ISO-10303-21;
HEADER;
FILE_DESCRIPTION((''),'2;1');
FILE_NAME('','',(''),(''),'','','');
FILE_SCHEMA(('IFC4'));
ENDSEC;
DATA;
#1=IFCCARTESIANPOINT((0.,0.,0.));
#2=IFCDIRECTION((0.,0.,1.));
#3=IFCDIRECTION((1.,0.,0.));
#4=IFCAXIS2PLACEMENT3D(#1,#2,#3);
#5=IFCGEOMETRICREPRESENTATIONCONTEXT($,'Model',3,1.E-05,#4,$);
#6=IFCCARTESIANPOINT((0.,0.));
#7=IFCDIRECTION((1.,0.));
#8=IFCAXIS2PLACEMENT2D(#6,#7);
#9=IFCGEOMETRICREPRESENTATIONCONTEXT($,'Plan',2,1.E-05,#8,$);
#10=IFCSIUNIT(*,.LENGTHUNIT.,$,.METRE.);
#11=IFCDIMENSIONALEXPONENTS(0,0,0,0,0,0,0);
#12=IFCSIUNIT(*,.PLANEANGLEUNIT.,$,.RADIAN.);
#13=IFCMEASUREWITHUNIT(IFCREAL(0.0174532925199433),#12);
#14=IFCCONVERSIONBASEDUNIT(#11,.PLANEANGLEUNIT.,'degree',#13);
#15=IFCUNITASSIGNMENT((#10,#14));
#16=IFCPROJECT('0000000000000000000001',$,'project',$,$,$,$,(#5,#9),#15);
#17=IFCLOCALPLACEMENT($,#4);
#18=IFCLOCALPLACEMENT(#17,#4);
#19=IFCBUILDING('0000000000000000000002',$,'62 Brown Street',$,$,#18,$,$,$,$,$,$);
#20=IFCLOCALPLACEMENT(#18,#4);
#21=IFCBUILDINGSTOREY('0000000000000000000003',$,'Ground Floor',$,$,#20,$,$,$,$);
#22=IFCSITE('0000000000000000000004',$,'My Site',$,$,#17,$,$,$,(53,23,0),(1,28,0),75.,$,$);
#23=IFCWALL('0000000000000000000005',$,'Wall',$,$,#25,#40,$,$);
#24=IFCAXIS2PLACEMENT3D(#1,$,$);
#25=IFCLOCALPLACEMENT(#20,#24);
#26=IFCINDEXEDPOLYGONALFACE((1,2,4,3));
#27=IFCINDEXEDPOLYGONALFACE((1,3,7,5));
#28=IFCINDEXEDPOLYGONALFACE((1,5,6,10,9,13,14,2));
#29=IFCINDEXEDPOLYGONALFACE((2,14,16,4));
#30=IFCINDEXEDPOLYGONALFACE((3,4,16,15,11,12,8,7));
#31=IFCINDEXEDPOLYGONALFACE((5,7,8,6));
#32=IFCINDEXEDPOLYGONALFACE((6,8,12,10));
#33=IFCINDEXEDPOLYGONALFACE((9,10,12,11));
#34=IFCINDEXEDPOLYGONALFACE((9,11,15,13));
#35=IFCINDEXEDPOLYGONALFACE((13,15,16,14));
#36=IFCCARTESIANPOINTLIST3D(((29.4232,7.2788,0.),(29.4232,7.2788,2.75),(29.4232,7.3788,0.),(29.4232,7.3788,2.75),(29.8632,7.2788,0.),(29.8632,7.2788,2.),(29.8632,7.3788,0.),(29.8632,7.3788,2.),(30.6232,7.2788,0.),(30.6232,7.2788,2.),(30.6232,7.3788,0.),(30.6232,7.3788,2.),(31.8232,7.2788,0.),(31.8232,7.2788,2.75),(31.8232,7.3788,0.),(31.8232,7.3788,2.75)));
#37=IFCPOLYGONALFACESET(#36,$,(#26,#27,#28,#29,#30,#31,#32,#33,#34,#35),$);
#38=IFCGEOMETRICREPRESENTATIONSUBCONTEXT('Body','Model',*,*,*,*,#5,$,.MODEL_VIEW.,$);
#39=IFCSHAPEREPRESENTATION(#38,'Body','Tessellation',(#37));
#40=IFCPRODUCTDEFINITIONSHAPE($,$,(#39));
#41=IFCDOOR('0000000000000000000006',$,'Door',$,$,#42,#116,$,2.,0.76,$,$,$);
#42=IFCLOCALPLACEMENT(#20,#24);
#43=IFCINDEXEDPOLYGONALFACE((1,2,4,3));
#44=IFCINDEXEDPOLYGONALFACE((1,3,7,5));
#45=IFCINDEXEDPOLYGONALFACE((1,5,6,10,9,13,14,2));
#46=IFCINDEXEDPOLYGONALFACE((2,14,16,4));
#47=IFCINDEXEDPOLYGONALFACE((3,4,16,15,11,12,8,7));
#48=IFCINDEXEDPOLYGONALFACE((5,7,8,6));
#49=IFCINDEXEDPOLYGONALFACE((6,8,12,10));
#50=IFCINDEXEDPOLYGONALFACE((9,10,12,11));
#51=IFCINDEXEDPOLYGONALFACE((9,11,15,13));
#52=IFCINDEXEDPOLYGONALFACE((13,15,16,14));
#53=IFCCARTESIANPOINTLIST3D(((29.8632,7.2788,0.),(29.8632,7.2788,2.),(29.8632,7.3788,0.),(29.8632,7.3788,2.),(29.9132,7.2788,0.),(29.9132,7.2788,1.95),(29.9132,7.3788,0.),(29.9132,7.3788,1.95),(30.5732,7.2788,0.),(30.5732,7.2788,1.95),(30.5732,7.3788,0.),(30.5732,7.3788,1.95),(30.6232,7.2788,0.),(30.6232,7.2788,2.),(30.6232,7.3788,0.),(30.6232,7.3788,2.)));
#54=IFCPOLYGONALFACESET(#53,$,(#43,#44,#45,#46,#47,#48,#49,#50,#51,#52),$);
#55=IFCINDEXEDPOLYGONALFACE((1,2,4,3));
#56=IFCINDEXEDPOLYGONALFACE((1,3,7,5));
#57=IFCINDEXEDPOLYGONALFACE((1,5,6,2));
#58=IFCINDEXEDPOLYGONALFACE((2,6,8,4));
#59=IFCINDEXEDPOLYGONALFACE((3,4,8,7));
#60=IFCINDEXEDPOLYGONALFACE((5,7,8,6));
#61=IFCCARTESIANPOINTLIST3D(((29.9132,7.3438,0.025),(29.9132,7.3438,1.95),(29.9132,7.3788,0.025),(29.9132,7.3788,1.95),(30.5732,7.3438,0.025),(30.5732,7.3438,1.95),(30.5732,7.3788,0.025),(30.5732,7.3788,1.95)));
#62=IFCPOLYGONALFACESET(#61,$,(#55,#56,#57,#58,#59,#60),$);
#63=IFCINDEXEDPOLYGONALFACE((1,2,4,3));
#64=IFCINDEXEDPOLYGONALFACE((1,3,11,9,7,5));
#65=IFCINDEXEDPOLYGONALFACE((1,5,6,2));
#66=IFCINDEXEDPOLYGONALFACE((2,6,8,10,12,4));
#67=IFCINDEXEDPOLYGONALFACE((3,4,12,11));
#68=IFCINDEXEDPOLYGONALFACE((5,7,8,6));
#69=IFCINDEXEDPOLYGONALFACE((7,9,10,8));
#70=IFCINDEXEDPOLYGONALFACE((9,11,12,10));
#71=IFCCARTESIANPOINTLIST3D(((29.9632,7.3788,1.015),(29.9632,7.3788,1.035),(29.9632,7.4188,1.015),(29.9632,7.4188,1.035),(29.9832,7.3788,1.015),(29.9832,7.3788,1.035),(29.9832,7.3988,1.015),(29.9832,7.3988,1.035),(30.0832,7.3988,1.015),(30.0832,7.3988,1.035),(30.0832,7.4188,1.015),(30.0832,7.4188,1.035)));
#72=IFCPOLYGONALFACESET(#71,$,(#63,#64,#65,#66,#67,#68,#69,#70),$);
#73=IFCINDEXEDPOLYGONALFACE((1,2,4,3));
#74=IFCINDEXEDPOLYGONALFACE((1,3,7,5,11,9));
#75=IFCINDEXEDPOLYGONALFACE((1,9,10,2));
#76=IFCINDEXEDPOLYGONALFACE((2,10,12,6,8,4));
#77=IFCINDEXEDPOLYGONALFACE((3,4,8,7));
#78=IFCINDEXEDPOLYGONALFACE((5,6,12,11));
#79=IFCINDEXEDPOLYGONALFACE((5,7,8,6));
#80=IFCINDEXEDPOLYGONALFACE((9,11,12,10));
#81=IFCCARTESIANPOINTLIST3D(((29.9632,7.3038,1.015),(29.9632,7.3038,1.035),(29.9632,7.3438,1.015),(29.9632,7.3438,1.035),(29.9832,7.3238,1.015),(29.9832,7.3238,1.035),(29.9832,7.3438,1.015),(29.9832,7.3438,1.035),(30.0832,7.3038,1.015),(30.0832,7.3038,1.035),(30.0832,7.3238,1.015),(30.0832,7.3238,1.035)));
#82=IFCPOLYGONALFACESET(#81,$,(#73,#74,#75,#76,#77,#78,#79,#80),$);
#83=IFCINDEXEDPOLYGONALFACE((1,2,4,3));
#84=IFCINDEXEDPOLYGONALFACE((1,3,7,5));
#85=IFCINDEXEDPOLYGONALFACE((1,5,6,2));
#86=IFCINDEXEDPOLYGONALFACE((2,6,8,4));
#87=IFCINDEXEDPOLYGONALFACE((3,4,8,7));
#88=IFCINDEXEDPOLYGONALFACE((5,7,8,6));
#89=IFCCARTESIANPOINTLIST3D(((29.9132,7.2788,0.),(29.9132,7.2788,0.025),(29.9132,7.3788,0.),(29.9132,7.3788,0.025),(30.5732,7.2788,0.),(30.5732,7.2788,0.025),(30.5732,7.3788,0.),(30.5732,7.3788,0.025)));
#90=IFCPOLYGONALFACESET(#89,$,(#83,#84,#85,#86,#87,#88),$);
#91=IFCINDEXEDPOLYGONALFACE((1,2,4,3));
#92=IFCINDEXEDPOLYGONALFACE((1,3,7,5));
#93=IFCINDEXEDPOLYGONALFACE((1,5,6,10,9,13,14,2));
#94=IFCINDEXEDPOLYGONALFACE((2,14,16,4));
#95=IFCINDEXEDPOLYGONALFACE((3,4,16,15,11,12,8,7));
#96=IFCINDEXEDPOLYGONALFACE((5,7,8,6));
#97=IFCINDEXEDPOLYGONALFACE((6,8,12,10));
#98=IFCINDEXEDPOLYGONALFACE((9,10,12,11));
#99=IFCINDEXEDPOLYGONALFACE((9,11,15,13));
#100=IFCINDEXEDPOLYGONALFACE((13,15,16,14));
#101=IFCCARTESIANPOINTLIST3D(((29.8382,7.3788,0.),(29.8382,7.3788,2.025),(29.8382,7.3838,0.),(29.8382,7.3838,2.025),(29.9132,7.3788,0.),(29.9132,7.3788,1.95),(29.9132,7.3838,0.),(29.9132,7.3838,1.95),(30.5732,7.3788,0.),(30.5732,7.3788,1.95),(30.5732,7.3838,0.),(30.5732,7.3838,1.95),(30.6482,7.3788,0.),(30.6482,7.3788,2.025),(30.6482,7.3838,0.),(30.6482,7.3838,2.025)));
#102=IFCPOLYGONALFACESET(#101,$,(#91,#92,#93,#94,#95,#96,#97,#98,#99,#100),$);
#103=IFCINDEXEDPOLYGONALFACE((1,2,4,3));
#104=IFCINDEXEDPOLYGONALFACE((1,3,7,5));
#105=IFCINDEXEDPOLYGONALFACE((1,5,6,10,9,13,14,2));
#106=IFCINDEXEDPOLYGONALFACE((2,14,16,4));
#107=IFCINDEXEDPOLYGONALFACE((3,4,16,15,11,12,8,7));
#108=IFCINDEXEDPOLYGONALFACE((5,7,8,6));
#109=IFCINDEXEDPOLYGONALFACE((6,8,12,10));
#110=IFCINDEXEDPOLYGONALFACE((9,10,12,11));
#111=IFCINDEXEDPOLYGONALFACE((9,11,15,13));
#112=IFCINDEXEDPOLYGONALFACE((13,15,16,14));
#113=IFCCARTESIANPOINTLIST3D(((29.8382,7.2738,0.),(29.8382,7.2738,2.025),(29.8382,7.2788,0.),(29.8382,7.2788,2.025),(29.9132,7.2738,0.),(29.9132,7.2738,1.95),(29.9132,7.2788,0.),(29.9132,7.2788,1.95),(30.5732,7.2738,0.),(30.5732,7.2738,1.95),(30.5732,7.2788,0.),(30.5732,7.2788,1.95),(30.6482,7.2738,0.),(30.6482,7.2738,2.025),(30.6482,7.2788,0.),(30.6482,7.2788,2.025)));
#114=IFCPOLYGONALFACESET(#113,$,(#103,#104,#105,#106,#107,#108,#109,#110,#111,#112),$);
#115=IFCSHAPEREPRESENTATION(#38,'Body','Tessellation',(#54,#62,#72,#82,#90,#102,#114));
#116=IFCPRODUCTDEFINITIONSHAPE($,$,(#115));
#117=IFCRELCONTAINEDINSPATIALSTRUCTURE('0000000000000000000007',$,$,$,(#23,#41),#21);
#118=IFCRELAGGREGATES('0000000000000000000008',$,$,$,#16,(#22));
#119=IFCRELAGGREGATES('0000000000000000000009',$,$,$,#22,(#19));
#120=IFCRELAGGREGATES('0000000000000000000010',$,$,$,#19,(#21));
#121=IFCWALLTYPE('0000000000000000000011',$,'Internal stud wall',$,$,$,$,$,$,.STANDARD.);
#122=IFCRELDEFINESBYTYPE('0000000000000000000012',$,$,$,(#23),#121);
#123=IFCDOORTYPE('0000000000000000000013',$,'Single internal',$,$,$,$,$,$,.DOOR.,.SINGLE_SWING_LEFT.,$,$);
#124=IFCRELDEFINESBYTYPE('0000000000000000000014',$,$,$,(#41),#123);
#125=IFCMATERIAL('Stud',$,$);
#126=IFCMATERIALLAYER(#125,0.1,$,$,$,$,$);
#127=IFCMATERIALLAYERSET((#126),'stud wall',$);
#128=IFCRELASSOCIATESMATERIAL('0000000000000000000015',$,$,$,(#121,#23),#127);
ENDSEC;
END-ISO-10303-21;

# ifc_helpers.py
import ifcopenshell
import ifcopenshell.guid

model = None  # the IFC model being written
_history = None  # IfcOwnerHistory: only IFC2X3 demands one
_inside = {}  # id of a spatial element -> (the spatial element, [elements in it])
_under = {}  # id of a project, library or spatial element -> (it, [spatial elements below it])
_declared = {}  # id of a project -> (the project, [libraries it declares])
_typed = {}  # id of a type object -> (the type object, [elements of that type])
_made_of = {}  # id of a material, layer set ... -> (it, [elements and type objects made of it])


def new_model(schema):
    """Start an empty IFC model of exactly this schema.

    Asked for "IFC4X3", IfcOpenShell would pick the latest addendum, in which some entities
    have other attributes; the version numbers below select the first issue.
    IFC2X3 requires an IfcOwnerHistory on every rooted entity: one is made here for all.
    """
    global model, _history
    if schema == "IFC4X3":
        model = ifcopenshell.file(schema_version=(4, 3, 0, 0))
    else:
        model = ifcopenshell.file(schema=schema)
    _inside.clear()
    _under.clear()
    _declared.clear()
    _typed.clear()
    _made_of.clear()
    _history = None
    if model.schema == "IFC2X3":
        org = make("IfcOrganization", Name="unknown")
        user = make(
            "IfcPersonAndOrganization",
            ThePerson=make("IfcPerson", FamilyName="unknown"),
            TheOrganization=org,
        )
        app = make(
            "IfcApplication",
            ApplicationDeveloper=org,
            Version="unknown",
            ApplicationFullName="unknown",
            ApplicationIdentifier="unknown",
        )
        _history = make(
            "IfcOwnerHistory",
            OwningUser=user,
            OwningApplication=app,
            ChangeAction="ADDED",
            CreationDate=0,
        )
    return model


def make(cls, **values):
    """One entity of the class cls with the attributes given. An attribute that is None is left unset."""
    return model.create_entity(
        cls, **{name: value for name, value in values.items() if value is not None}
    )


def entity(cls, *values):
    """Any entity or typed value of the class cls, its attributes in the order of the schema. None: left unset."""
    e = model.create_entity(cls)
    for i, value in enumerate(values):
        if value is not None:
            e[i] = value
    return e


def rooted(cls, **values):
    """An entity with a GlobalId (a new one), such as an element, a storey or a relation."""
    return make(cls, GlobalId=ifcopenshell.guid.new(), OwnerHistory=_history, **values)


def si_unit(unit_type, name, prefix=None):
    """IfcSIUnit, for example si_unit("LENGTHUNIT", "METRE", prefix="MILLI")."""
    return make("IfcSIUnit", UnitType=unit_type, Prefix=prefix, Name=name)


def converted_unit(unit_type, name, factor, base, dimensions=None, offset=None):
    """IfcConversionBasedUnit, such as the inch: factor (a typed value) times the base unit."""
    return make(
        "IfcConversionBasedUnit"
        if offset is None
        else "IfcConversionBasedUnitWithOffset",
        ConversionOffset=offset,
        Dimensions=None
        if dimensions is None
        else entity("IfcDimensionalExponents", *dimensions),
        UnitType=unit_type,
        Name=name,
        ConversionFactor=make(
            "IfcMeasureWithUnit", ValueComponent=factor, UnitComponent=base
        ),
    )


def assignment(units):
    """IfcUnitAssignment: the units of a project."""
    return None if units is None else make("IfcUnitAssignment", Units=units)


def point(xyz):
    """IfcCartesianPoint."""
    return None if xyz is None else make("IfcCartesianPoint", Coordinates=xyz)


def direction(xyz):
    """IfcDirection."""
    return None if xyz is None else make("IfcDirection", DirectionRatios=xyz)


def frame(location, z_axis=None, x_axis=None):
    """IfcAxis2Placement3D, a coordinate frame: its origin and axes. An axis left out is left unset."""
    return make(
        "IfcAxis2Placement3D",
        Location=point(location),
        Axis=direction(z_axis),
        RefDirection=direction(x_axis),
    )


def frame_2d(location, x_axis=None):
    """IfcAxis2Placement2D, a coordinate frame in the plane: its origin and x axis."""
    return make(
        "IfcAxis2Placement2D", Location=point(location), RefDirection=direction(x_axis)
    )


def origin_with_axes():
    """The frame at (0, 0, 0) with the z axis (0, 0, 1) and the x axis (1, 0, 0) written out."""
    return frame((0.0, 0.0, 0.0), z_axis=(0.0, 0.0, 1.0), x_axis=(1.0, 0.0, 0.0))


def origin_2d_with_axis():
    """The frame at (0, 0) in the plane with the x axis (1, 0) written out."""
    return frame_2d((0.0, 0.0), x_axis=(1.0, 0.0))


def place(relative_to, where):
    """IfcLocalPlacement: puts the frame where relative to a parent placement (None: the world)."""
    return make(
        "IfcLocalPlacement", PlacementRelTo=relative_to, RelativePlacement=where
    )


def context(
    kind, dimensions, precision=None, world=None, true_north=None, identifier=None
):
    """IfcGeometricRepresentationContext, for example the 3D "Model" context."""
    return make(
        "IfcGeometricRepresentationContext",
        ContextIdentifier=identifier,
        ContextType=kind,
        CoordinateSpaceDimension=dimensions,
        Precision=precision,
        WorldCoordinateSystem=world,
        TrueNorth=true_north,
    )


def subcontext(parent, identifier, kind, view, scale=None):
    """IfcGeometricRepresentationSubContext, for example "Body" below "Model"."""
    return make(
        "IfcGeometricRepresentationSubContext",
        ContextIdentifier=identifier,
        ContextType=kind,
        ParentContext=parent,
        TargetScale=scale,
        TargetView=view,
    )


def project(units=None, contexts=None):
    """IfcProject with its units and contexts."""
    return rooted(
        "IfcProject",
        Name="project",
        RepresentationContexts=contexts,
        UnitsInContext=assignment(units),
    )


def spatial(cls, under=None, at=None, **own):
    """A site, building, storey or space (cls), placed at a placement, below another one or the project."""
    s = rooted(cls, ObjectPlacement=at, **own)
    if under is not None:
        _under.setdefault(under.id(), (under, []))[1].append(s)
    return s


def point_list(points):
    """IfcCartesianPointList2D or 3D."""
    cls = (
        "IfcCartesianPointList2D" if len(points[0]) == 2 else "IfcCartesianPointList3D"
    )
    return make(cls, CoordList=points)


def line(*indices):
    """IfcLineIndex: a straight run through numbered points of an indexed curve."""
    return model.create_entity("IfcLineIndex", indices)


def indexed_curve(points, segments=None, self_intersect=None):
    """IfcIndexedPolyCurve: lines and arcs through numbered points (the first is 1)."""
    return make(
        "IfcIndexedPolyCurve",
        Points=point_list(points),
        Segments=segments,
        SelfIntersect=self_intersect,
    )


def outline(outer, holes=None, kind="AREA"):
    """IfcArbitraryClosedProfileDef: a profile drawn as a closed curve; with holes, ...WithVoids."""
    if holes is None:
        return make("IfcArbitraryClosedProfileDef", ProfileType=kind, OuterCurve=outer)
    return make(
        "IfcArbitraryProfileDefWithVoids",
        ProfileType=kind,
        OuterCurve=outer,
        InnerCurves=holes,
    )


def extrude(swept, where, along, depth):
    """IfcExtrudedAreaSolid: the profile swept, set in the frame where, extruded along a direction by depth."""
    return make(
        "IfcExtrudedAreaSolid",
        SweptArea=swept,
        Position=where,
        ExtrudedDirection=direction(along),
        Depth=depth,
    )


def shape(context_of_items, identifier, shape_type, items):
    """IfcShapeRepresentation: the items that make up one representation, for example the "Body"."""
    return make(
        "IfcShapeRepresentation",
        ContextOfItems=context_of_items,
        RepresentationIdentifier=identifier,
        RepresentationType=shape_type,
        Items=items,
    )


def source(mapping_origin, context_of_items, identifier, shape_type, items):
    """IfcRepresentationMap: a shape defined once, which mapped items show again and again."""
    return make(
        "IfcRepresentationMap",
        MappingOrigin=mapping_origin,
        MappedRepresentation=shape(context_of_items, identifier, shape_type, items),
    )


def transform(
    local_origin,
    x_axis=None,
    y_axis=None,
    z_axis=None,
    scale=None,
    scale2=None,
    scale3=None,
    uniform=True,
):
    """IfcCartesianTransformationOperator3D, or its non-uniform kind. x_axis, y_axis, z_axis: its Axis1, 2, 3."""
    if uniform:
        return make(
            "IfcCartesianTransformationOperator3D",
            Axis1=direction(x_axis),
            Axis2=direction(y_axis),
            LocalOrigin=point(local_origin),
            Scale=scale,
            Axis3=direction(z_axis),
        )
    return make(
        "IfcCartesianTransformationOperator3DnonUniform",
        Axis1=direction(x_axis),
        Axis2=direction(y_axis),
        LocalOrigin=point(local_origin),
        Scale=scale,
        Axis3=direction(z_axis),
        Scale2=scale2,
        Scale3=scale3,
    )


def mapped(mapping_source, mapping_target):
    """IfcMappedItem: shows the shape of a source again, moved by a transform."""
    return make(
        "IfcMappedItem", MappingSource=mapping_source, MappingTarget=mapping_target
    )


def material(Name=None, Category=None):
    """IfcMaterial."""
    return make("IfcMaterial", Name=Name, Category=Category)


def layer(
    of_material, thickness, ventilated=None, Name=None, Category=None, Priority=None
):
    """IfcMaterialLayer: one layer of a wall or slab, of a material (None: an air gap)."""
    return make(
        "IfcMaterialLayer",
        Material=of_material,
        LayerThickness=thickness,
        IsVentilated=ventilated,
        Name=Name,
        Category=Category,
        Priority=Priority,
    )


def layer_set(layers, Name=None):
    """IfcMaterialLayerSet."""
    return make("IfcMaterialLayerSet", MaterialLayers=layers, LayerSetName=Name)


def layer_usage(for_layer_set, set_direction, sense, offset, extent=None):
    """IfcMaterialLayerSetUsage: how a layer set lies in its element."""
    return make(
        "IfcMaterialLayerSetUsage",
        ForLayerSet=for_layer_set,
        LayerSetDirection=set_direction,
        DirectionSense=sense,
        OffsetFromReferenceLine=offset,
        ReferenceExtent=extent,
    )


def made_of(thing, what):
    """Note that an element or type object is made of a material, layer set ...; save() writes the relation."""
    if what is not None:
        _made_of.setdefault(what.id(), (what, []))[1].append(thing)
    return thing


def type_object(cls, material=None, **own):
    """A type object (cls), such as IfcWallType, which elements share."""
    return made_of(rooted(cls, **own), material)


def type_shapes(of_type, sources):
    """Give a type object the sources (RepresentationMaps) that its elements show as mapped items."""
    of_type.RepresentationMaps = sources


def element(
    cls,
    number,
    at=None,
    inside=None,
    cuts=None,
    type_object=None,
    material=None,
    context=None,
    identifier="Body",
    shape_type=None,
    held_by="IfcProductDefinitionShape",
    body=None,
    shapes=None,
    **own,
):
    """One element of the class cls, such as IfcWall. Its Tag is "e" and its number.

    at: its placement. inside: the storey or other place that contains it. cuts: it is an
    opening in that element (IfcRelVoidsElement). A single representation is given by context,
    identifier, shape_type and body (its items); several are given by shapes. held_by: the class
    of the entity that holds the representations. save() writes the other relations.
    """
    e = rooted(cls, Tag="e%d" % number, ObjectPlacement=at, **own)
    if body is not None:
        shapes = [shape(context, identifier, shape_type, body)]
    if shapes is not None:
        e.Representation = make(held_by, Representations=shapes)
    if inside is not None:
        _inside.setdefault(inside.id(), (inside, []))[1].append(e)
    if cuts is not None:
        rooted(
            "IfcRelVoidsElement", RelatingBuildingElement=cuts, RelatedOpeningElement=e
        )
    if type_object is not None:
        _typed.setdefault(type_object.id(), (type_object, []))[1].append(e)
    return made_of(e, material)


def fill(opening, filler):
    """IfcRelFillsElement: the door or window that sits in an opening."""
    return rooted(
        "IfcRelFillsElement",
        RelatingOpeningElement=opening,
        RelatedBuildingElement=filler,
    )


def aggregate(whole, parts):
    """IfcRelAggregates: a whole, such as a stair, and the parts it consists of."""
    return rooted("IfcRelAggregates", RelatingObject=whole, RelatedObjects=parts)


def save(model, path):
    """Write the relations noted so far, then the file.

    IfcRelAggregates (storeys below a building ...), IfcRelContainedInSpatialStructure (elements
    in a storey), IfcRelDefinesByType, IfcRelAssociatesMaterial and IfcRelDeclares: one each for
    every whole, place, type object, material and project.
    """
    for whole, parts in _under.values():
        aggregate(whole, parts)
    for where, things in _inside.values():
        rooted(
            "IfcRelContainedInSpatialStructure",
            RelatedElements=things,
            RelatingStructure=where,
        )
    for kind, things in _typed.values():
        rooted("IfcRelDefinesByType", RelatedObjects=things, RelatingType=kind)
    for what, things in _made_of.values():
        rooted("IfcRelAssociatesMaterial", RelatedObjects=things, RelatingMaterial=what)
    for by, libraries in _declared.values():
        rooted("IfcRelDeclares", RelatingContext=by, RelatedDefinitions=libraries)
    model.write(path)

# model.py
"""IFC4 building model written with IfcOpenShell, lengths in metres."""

from ifc_helpers import new_model, entity, si_unit, converted_unit, frame, origin_with_axes, origin_2d_with_axis, place, context, subcontext, project, spatial, line, indexed_curve, outline, extrude, shape, source, transform, mapped, material, layer, layer_set, layer_usage, type_object, type_shapes, element, fill, save


model = new_model("IFC4")

# Units and contexts
model_context = context("Model", 3, precision=1e-05, world=origin_with_axes())
plan_context = context("Plan", 2, precision=1e-05, world=origin_2d_with_axis())
body_context_1 = subcontext(model_context, "Body", "Model", "MODEL_VIEW")
body_context_2 = subcontext(plan_context, "Body", "Plan", "PLAN_VIEW")
ifc_project = project(units=[si_unit("LENGTHUNIT", "METRE"), converted_unit("PLANEANGLEUNIT", "degree", entity("IfcReal", 0.0174532925199433), si_unit("PLANEANGLEUNIT", "RADIAN"), dimensions=[0, 0, 0, 0, 0, 0, 0])], contexts=[model_context, plan_context])

# Site, building, storey
site_placement = place(None, origin_with_axes())
site = spatial("IfcSite", under=ifc_project, at=site_placement, Name="My Site", RefLatitude=(53, 23, 0), RefLongitude=(1, 28, 0), RefElevation=75.0)
building_placement = place(site_placement, origin_with_axes())
building = spatial("IfcBuilding", under=site, at=building_placement, Name="62 Brown Street")
storey_placement = place(building_placement, origin_with_axes())
storey = spatial("IfcBuildingStorey", under=building, at=storey_placement, Name="Ground Floor")

# Wall, opening, door
ifc_material_1 = material(Name="Stud")
ifc_layer_1 = layer(ifc_material_1, 0.1)
ifc_layer_set_1 = layer_set([ifc_layer_1], Name="stud wall")
ifc_layer_usage_1 = layer_usage(ifc_layer_set_1, "AXIS2", "POSITIVE", 0.0)
wall_type_1 = type_object("IfcWallType", Name="Internal stud wall", PredefinedType="STANDARD", material=ifc_layer_set_1)
wall_1_placement = place(storey_placement, frame((31.8232, 7.3788, 0.0), z_axis=(0.0, 0.0, 1.0), x_axis=(-1.0, 0.0, 0.0)))
wall_1 = element("IfcWall", 1, at=wall_1_placement, inside=storey, type_object=wall_type_1, material=ifc_layer_usage_1, Name="Wall", context=body_context_1, shape_type="SweptSolid", body=[
    extrude(outline(indexed_curve([(0.0, 0.0), (0.0, 0.1), (2.4, 0.1), (2.4, 0.0), (0.0, 0.0)], self_intersect=False)), origin_with_axes(), (0.0, 0.0, 1.0), 2.75),
])
shared_shape_1 = source(origin_with_axes(), body_context_1, "Body", "SweptSolid", [
    extrude(outline(indexed_curve([(0.0, 0.0), (0.76, 0.0), (0.76, 2.0), (0.0, 2.0)], segments=[line(1, 2, 3, 4, 1)])), frame((0.0, -0.6, 0.0), z_axis=(0.0, -1.0, 0.0), x_axis=(1.0, 0.0, 0.0)), (0.0, 0.0, -1.0), 1.2),
])
opening_1_placement = place(wall_1_placement, frame((1.2, 0.0, 0.0), z_axis=(0.0, 0.0, 1.0), x_axis=(1.0, 0.0, 0.0)))
opening_1 = element("IfcOpeningElement", 2, at=opening_1_placement, cuts=wall_1, PredefinedType="OPENING", context=body_context_1, shape_type="MappedRepresentation", body=[
    mapped(shared_shape_1, transform((0.0, 0.0, 0.0), x_axis=(1.0, 0.0, 0.0), y_axis=(0.0, 1.0, 0.0), z_axis=(0.0, 0.0, 1.0), scale=1.0)),
])
door_type_1 = type_object("IfcDoorType", Name="Single internal", OperationType="SINGLE_SWING_LEFT", PredefinedType="DOOR")
shared_shape_2 = source(origin_with_axes(), body_context_1, "Body", "SweptSolid", [
    extrude(outline(indexed_curve([(0.0, 0.0), (0.0, 2.0), (0.76, 2.0), (0.76, 0.0), (0.71, 0.0), (0.71, 1.95), (0.05, 1.95), (0.05, 0.0)], segments=[line(1, 2, 3, 4, 5, 6, 7, 8, 1)])), frame((0.0, 0.0, 0.0), z_axis=(0.0, -1.0, 0.0), x_axis=(1.0, 0.0, 0.0)), (0.0, 0.0, -1.0), 0.1),
    extrude(outline(indexed_curve([(0.0, 0.0), (0.66, 0.0), (0.66, 0.035), (0.0, 0.035)], segments=[line(1, 2, 3, 4, 1)])), frame((0.05, 0.0, 0.025), z_axis=(0.0, 0.0, 1.0), x_axis=(1.0, 0.0, 0.0)), (0.0, 0.0, 1.0), 1.925),
    extrude(outline(indexed_curve([(0.0, 0.0), (0.0, -0.04), (-0.12, -0.04), (-0.12, -0.02), (-0.02, -0.02), (-0.02, 0.0)], segments=[line(1, 2, 3, 4, 5, 6, 1)])), frame((0.66, 0.0, 1.015), z_axis=(0.0, 0.0, 1.0), x_axis=(1.0, 0.0, 0.0)), (0.0, 0.0, 1.0), 0.02),
    extrude(outline(indexed_curve([(0.0, 0.0), (0.0, 0.04), (-0.12, 0.04), (-0.12, 0.02), (-0.02, 0.02), (-0.02, 0.0)], segments=[line(1, 2, 3, 4, 5, 6, 1)])), frame((0.66, 0.035, 1.015), z_axis=(0.0, 0.0, 1.0), x_axis=(1.0, 0.0, 0.0)), (0.0, 0.0, 1.0), 0.02),
    extrude(outline(indexed_curve([(0.0, 0.0), (0.66, 0.0), (0.66, 0.1), (0.0, 0.1)], segments=[line(1, 2, 3, 4, 1)])), frame((0.05, 0.0, 0.0), z_axis=(0.0, 0.0, 1.0), x_axis=(1.0, 0.0, 0.0)), (0.0, 0.0, 1.0), 0.025),
    extrude(outline(indexed_curve([(0.0, 0.0), (0.0, 2.025), (0.81, 2.025), (0.81, 0.0), (0.735, 0.0), (0.735, 1.95), (0.075, 1.95), (0.075, 0.0)], segments=[line(1, 2, 3, 4, 5, 6, 7, 8, 1)])), frame((-0.025, -0.005, 0.0), z_axis=(0.0, -1.0, 0.0), x_axis=(1.0, 0.0, 0.0)), (0.0, 0.0, -1.0), 0.005),
    extrude(outline(indexed_curve([(0.0, 0.0), (0.0, 2.025), (0.81, 2.025), (0.81, 0.0), (0.735, 0.0), (0.735, 1.95), (0.075, 1.95), (0.075, 0.0)], segments=[line(1, 2, 3, 4, 5, 6, 7, 8, 1)])), frame((-0.025, 0.1, 0.0), z_axis=(0.0, -1.0, 0.0), x_axis=(1.0, 0.0, 0.0)), (0.0, 0.0, -1.0), 0.005),
])
shared_shape_3 = source(origin_with_axes(), body_context_2, "Body", "Curve2D", [
    entity("IfcIndexedPolyCurve", entity("IfcCartesianPointList2D", [[0.0, 0.0], [0.05, 0.0], [0.05, 0.1], [0.0, 0.1]]), [entity("IfcLineIndex", [1, 2, 3, 4, 1])]),
    entity("IfcIndexedPolyCurve", entity("IfcCartesianPointList2D", [[0.76, 0.0], [0.71, 0.0], [0.71, 0.1], [0.76, 0.1]]), [entity("IfcLineIndex", [1, 2, 3, 4, 1])]),
    entity("IfcTrimmedCurve", entity("IfcEllipse", entity("IfcAxis2Placement2D", entity("IfcCartesianPoint", [0.085, 0.1]), entity("IfcDirection", [1.0, 0.0])), 0.625, 0.66), [entity("IfcCartesianPoint", [0.71, 0.1])], [entity("IfcCartesianPoint", [0.085, 0.76])], True, "CARTESIAN"),
    entity("IfcIndexedPolyCurve", entity("IfcCartesianPointList2D", [[0.05, 0.1], [0.085, 0.1], [0.085, 0.76], [0.05, 0.76]]), [entity("IfcLineIndex", [1, 2, 3, 4, 1])]),
])
type_shapes(door_type_1, [shared_shape_2, shared_shape_3])
door_1_placement = place(opening_1_placement, frame((0.0, 0.0, 0.0), z_axis=(0.0, 0.0, 1.0), x_axis=(1.0, 0.0, 0.0)))
door_1 = element("IfcDoor", 3, at=door_1_placement, inside=storey, type_object=door_type_1, Name="Door", OverallHeight=2.0, OverallWidth=0.76, shapes=[
    shape(body_context_1, "Body", "MappedRepresentation", [mapped(shared_shape_2, transform((0.0, 0.0, 0.0), x_axis=(1.0, 0.0, 0.0), y_axis=(0.0, 1.0, 0.0), z_axis=(0.0, 0.0, 1.0), scale=1.0))]),
    shape(body_context_2, "Body", "MappedRepresentation", [mapped(shared_shape_3, transform((0.0, 0.0, 0.0), x_axis=(1.0, 0.0, 0.0), y_axis=(0.0, 1.0, 0.0), z_axis=(0.0, 0.0, 1.0), scale=1.0))]),
])
fill(opening_1, door_1)

save(model, "model.ifc")
